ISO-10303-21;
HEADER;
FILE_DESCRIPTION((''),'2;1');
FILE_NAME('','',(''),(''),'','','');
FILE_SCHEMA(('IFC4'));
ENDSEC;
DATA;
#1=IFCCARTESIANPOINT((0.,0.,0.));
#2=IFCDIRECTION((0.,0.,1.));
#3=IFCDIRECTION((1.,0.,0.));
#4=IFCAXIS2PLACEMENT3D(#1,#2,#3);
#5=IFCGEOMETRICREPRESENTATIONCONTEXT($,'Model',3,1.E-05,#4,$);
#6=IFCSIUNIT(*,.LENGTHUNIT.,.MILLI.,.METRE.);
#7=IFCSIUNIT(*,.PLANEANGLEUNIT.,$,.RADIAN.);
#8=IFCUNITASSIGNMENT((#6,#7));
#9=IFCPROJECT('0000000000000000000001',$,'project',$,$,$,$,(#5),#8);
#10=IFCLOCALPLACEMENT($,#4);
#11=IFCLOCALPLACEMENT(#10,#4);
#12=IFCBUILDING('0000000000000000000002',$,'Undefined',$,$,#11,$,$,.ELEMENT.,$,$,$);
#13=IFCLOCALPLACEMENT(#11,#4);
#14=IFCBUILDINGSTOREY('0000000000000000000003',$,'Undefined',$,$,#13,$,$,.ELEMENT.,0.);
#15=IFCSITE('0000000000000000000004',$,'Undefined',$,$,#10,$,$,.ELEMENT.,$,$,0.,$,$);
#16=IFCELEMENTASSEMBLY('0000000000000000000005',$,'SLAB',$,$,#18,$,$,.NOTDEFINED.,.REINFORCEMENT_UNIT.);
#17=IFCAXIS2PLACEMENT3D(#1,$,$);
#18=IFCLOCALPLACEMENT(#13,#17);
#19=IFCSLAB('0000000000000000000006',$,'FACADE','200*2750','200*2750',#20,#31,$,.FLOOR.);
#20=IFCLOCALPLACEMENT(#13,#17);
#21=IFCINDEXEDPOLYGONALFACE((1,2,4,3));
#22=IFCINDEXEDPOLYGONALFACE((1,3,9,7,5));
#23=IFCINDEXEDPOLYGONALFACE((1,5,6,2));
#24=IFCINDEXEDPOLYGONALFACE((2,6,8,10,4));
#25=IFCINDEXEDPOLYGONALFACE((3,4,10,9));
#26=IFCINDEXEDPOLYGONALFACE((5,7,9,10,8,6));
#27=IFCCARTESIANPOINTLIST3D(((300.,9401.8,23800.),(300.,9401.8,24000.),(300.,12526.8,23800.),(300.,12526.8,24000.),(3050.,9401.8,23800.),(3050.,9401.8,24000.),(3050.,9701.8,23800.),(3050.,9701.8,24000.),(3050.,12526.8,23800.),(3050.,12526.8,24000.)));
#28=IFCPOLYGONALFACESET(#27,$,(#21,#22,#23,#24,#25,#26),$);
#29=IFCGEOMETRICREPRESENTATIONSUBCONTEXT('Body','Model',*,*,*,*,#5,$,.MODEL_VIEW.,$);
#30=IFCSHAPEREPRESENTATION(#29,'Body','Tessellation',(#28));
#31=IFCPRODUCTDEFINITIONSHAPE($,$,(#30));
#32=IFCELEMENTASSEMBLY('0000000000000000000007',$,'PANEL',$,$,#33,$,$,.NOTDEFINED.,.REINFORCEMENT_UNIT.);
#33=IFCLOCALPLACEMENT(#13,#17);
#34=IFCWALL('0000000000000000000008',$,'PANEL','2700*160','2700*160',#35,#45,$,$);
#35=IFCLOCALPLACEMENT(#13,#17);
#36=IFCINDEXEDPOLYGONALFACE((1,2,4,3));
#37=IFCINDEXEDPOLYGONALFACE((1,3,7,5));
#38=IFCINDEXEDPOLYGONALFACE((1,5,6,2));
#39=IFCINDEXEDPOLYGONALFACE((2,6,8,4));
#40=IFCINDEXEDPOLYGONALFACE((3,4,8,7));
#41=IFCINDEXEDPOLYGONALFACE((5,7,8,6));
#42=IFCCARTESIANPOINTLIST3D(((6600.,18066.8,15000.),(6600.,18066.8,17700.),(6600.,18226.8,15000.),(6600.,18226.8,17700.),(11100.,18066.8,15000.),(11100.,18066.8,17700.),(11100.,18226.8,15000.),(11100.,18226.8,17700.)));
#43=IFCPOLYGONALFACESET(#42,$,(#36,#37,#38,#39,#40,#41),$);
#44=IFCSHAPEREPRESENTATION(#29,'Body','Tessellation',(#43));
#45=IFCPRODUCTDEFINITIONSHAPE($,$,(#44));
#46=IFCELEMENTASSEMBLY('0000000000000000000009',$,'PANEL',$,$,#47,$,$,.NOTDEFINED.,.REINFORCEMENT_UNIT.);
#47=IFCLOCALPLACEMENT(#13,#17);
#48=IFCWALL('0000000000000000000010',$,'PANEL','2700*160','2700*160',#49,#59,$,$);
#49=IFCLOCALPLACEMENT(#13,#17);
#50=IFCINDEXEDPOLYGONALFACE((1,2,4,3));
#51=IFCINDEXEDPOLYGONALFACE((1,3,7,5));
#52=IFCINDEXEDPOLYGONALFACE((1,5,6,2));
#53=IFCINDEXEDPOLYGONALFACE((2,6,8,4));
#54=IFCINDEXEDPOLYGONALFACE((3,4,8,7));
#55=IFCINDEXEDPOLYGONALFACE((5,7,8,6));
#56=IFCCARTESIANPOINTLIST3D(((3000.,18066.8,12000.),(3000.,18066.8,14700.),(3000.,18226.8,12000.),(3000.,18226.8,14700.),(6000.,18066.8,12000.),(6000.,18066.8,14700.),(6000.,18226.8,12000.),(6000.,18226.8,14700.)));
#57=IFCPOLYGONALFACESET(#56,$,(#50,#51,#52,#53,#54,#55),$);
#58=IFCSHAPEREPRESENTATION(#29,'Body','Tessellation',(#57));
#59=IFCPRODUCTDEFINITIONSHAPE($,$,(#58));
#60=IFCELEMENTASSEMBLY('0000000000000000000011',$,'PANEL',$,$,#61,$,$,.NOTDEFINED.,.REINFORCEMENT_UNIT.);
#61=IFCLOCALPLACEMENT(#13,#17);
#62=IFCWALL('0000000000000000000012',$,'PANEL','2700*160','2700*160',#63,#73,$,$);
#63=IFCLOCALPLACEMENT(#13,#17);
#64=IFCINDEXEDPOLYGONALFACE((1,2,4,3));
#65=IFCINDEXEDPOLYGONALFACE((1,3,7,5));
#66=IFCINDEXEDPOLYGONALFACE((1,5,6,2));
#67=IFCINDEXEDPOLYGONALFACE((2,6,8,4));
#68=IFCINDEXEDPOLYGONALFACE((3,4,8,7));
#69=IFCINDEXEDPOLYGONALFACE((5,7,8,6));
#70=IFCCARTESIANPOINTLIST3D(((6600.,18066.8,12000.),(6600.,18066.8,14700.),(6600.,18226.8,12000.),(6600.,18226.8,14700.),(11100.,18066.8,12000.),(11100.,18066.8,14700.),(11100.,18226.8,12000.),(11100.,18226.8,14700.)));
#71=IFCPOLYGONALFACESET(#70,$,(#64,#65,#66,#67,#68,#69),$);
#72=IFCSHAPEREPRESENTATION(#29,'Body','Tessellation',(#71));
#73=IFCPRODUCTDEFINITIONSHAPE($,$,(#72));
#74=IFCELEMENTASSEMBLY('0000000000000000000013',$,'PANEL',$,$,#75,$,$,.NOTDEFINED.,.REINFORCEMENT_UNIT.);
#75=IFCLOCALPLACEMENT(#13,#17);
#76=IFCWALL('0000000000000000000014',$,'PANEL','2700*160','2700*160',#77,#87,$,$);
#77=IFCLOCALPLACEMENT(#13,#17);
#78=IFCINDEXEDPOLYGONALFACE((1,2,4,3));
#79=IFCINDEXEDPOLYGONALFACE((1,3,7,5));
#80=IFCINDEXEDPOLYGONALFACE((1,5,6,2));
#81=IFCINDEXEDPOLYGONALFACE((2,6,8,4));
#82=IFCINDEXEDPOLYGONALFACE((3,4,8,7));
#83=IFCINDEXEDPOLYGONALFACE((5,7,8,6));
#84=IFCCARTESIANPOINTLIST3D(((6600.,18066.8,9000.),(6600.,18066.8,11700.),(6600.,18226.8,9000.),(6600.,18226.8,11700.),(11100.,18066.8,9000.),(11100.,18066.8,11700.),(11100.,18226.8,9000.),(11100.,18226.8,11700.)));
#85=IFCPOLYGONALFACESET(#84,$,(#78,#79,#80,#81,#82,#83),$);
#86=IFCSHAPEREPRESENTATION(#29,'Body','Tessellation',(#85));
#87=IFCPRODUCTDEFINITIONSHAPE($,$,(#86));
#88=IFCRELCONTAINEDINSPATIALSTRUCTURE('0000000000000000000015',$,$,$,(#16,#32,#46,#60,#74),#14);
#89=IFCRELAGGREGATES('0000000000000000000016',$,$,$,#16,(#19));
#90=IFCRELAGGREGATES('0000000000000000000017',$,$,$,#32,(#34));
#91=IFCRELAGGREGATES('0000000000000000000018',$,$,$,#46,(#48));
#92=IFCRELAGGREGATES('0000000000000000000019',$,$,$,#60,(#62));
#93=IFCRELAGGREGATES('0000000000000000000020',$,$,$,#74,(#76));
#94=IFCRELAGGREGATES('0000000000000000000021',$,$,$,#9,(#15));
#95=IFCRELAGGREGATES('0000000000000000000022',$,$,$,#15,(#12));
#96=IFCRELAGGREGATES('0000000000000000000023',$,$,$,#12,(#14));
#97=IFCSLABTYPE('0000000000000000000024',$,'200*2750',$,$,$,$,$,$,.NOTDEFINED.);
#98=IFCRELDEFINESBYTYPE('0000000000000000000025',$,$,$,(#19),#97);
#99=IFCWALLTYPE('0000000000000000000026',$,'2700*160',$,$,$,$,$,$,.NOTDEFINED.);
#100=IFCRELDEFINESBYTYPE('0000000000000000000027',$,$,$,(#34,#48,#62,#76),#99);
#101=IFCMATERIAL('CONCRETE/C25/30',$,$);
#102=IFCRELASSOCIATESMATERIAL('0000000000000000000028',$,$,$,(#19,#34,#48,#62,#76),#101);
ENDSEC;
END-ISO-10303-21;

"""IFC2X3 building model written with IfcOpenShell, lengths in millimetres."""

from ifc_helpers import new_model, si_unit, frame, frame_2d, origin_with_axes, place, context, subcontext, project, spatial, polyline, rectangle, outline, extrude, material, type_object, element, aggregate, save


model = new_model("IFC2X3")

# Units and contexts
model_context = context("Model", 3, precision=1e-05, world=origin_with_axes())
body_context = subcontext(model_context, "Body", "Model", "MODEL_VIEW")
ifc_project = project(units=[si_unit("LENGTHUNIT", "METRE", prefix="MILLI"), si_unit("PLANEANGLEUNIT", "RADIAN")], contexts=[model_context])

# Site, building, storey
site_placement = place(None, origin_with_axes())
site = spatial("IfcSite", under=ifc_project, at=site_placement, Name="Undefined", CompositionType="ELEMENT", RefElevation=0.0)
building_placement = place(site_placement, origin_with_axes())
building = spatial("IfcBuilding", under=site, at=building_placement, Name="Undefined", CompositionType="ELEMENT")
storey_placement = place(building_placement, origin_with_axes())
storey = spatial("IfcBuildingStorey", under=building, at=storey_placement, Name="Undefined", CompositionType="ELEMENT", Elevation=0.0)

# Shared definitions
ifc_material = material(Name="CONCRETE/C25/30")

# Element assembly, slab
assembly_1_placement = place(storey_placement, origin_with_axes())
assembly_1 = element("IfcElementAssembly", 1, at=assembly_1_placement, inside=storey, Name="SLAB", AssemblyPlace="NOTDEFINED", PredefinedType="REINFORCEMENT_UNIT")
slab_type = type_object("IfcSlabType", Name="200*2750", PredefinedType="NOTDEFINED")
slab_placement = place(assembly_1_placement, frame((3050.0, 9701.8, 23900.0), z_axis=(0.0, 0.0, 1.0), x_axis=(0.0, 1.0, 0.0)))
slab = element("IfcSlab", 2, at=slab_placement, type_object=slab_type, material=ifc_material, Name="FACADE", Description="200*2750", ObjectType="200*2750", PredefinedType="FLOOR", context=body_context, shape_type="SweptSolid", body=[
    extrude(outline(polyline([(0.0, 0.0), (2825.0, 0.0), (2825.0, 2750.0), (-300.0, 2750.0), (-300.0, 0.0), (0.0, 0.0), (0.0, 0.0)])), frame((0.0, 0.0, -100.0), z_axis=(0.0, 0.0, 1.0), x_axis=(1.0, 0.0, 0.0)), (0.0, 0.0, 1.0), 200.0),
])
aggregate(assembly_1, [slab])

# Element assemblies, walls
assembly_2_placement = place(storey_placement, origin_with_axes())
assembly_2 = element("IfcElementAssembly", 3, at=assembly_2_placement, inside=storey, Name="PANEL", AssemblyPlace="NOTDEFINED", PredefinedType="REINFORCEMENT_UNIT")
wall_type = type_object("IfcWallType", Name="2700*160", PredefinedType="NOTDEFINED")
wall_1_placement = place(assembly_2_placement, frame((6600.0, 18146.8, 15000.0), z_axis=(0.0, 0.0, 1.0), x_axis=(1.0, 0.0, 0.0)))
wall_1 = element("IfcWall", 4, at=wall_1_placement, type_object=wall_type, material=ifc_material, Name="PANEL", Description="2700*160", ObjectType="2700*160", context=body_context, shape_type="SweptSolid", body=[
    extrude(rectangle(XDim=4500.0, YDim=160.0, at=frame_2d((0.0, 2250.0), x_axis=(0.0, -1.0))), frame((0.0, 0.0, 0.0), z_axis=(0.0, 0.0, 1.0), x_axis=(0.0, -1.0, 0.0)), (0.0, 0.0, 1.0), 2700.0),
])
aggregate(assembly_2, [wall_1])
assembly_3_placement = place(storey_placement, origin_with_axes())
assembly_3 = element("IfcElementAssembly", 5, at=assembly_3_placement, inside=storey, Name="PANEL", AssemblyPlace="NOTDEFINED", PredefinedType="REINFORCEMENT_UNIT")
wall_2_placement = place(assembly_3_placement, frame((3000.0, 18146.8, 12000.0), z_axis=(0.0, 0.0, 1.0), x_axis=(1.0, 0.0, 0.0)))
wall_2 = element("IfcWall", 6, at=wall_2_placement, type_object=wall_type, material=ifc_material, Name="PANEL", Description="2700*160", ObjectType="2700*160", context=body_context, shape_type="SweptSolid", body=[
    extrude(rectangle(XDim=3000.0, YDim=160.0, at=frame_2d((0.0, 1500.0), x_axis=(0.0, -1.0))), frame((0.0, 0.0, 0.0), z_axis=(0.0, 0.0, 1.0), x_axis=(0.0, -1.0, 0.0)), (0.0, 0.0, 1.0), 2700.0),
])
aggregate(assembly_3, [wall_2])
assembly_4_placement = place(storey_placement, origin_with_axes())
assembly_4 = element("IfcElementAssembly", 7, at=assembly_4_placement, inside=storey, Name="PANEL", AssemblyPlace="NOTDEFINED", PredefinedType="REINFORCEMENT_UNIT")
wall_3_placement = place(assembly_4_placement, frame((6600.0, 18146.8, 12000.0), z_axis=(0.0, 0.0, 1.0), x_axis=(1.0, 0.0, 0.0)))
wall_3 = element("IfcWall", 8, at=wall_3_placement, type_object=wall_type, material=ifc_material, Name="PANEL", Description="2700*160", ObjectType="2700*160", context=body_context, shape_type="SweptSolid", body=[
    extrude(rectangle(XDim=4500.0, YDim=160.0, at=frame_2d((0.0, 2250.0), x_axis=(0.0, -1.0))), frame((0.0, 0.0, 0.0), z_axis=(0.0, 0.0, 1.0), x_axis=(0.0, -1.0, 0.0)), (0.0, 0.0, 1.0), 2700.0),
])
aggregate(assembly_4, [wall_3])
assembly_5_placement = place(storey_placement, origin_with_axes())
assembly_5 = element("IfcElementAssembly", 9, at=assembly_5_placement, inside=storey, Name="PANEL", AssemblyPlace="NOTDEFINED", PredefinedType="REINFORCEMENT_UNIT")
wall_4_placement = place(assembly_5_placement, frame((6600.0, 18146.8, 9000.0), z_axis=(0.0, 0.0, 1.0), x_axis=(1.0, 0.0, 0.0)))
wall_4 = element("IfcWall", 10, at=wall_4_placement, type_object=wall_type, material=ifc_material, Name="PANEL", Description="2700*160", ObjectType="2700*160", context=body_context, shape_type="SweptSolid", body=[
    extrude(rectangle(XDim=4500.0, YDim=160.0, at=frame_2d((0.0, 2250.0), x_axis=(0.0, -1.0))), frame((0.0, 0.0, 0.0), z_axis=(0.0, 0.0, 1.0), x_axis=(0.0, -1.0, 0.0)), (0.0, 0.0, 1.0), 2700.0),
])
aggregate(assembly_5, [wall_4])

save(model, "model.ifc")
